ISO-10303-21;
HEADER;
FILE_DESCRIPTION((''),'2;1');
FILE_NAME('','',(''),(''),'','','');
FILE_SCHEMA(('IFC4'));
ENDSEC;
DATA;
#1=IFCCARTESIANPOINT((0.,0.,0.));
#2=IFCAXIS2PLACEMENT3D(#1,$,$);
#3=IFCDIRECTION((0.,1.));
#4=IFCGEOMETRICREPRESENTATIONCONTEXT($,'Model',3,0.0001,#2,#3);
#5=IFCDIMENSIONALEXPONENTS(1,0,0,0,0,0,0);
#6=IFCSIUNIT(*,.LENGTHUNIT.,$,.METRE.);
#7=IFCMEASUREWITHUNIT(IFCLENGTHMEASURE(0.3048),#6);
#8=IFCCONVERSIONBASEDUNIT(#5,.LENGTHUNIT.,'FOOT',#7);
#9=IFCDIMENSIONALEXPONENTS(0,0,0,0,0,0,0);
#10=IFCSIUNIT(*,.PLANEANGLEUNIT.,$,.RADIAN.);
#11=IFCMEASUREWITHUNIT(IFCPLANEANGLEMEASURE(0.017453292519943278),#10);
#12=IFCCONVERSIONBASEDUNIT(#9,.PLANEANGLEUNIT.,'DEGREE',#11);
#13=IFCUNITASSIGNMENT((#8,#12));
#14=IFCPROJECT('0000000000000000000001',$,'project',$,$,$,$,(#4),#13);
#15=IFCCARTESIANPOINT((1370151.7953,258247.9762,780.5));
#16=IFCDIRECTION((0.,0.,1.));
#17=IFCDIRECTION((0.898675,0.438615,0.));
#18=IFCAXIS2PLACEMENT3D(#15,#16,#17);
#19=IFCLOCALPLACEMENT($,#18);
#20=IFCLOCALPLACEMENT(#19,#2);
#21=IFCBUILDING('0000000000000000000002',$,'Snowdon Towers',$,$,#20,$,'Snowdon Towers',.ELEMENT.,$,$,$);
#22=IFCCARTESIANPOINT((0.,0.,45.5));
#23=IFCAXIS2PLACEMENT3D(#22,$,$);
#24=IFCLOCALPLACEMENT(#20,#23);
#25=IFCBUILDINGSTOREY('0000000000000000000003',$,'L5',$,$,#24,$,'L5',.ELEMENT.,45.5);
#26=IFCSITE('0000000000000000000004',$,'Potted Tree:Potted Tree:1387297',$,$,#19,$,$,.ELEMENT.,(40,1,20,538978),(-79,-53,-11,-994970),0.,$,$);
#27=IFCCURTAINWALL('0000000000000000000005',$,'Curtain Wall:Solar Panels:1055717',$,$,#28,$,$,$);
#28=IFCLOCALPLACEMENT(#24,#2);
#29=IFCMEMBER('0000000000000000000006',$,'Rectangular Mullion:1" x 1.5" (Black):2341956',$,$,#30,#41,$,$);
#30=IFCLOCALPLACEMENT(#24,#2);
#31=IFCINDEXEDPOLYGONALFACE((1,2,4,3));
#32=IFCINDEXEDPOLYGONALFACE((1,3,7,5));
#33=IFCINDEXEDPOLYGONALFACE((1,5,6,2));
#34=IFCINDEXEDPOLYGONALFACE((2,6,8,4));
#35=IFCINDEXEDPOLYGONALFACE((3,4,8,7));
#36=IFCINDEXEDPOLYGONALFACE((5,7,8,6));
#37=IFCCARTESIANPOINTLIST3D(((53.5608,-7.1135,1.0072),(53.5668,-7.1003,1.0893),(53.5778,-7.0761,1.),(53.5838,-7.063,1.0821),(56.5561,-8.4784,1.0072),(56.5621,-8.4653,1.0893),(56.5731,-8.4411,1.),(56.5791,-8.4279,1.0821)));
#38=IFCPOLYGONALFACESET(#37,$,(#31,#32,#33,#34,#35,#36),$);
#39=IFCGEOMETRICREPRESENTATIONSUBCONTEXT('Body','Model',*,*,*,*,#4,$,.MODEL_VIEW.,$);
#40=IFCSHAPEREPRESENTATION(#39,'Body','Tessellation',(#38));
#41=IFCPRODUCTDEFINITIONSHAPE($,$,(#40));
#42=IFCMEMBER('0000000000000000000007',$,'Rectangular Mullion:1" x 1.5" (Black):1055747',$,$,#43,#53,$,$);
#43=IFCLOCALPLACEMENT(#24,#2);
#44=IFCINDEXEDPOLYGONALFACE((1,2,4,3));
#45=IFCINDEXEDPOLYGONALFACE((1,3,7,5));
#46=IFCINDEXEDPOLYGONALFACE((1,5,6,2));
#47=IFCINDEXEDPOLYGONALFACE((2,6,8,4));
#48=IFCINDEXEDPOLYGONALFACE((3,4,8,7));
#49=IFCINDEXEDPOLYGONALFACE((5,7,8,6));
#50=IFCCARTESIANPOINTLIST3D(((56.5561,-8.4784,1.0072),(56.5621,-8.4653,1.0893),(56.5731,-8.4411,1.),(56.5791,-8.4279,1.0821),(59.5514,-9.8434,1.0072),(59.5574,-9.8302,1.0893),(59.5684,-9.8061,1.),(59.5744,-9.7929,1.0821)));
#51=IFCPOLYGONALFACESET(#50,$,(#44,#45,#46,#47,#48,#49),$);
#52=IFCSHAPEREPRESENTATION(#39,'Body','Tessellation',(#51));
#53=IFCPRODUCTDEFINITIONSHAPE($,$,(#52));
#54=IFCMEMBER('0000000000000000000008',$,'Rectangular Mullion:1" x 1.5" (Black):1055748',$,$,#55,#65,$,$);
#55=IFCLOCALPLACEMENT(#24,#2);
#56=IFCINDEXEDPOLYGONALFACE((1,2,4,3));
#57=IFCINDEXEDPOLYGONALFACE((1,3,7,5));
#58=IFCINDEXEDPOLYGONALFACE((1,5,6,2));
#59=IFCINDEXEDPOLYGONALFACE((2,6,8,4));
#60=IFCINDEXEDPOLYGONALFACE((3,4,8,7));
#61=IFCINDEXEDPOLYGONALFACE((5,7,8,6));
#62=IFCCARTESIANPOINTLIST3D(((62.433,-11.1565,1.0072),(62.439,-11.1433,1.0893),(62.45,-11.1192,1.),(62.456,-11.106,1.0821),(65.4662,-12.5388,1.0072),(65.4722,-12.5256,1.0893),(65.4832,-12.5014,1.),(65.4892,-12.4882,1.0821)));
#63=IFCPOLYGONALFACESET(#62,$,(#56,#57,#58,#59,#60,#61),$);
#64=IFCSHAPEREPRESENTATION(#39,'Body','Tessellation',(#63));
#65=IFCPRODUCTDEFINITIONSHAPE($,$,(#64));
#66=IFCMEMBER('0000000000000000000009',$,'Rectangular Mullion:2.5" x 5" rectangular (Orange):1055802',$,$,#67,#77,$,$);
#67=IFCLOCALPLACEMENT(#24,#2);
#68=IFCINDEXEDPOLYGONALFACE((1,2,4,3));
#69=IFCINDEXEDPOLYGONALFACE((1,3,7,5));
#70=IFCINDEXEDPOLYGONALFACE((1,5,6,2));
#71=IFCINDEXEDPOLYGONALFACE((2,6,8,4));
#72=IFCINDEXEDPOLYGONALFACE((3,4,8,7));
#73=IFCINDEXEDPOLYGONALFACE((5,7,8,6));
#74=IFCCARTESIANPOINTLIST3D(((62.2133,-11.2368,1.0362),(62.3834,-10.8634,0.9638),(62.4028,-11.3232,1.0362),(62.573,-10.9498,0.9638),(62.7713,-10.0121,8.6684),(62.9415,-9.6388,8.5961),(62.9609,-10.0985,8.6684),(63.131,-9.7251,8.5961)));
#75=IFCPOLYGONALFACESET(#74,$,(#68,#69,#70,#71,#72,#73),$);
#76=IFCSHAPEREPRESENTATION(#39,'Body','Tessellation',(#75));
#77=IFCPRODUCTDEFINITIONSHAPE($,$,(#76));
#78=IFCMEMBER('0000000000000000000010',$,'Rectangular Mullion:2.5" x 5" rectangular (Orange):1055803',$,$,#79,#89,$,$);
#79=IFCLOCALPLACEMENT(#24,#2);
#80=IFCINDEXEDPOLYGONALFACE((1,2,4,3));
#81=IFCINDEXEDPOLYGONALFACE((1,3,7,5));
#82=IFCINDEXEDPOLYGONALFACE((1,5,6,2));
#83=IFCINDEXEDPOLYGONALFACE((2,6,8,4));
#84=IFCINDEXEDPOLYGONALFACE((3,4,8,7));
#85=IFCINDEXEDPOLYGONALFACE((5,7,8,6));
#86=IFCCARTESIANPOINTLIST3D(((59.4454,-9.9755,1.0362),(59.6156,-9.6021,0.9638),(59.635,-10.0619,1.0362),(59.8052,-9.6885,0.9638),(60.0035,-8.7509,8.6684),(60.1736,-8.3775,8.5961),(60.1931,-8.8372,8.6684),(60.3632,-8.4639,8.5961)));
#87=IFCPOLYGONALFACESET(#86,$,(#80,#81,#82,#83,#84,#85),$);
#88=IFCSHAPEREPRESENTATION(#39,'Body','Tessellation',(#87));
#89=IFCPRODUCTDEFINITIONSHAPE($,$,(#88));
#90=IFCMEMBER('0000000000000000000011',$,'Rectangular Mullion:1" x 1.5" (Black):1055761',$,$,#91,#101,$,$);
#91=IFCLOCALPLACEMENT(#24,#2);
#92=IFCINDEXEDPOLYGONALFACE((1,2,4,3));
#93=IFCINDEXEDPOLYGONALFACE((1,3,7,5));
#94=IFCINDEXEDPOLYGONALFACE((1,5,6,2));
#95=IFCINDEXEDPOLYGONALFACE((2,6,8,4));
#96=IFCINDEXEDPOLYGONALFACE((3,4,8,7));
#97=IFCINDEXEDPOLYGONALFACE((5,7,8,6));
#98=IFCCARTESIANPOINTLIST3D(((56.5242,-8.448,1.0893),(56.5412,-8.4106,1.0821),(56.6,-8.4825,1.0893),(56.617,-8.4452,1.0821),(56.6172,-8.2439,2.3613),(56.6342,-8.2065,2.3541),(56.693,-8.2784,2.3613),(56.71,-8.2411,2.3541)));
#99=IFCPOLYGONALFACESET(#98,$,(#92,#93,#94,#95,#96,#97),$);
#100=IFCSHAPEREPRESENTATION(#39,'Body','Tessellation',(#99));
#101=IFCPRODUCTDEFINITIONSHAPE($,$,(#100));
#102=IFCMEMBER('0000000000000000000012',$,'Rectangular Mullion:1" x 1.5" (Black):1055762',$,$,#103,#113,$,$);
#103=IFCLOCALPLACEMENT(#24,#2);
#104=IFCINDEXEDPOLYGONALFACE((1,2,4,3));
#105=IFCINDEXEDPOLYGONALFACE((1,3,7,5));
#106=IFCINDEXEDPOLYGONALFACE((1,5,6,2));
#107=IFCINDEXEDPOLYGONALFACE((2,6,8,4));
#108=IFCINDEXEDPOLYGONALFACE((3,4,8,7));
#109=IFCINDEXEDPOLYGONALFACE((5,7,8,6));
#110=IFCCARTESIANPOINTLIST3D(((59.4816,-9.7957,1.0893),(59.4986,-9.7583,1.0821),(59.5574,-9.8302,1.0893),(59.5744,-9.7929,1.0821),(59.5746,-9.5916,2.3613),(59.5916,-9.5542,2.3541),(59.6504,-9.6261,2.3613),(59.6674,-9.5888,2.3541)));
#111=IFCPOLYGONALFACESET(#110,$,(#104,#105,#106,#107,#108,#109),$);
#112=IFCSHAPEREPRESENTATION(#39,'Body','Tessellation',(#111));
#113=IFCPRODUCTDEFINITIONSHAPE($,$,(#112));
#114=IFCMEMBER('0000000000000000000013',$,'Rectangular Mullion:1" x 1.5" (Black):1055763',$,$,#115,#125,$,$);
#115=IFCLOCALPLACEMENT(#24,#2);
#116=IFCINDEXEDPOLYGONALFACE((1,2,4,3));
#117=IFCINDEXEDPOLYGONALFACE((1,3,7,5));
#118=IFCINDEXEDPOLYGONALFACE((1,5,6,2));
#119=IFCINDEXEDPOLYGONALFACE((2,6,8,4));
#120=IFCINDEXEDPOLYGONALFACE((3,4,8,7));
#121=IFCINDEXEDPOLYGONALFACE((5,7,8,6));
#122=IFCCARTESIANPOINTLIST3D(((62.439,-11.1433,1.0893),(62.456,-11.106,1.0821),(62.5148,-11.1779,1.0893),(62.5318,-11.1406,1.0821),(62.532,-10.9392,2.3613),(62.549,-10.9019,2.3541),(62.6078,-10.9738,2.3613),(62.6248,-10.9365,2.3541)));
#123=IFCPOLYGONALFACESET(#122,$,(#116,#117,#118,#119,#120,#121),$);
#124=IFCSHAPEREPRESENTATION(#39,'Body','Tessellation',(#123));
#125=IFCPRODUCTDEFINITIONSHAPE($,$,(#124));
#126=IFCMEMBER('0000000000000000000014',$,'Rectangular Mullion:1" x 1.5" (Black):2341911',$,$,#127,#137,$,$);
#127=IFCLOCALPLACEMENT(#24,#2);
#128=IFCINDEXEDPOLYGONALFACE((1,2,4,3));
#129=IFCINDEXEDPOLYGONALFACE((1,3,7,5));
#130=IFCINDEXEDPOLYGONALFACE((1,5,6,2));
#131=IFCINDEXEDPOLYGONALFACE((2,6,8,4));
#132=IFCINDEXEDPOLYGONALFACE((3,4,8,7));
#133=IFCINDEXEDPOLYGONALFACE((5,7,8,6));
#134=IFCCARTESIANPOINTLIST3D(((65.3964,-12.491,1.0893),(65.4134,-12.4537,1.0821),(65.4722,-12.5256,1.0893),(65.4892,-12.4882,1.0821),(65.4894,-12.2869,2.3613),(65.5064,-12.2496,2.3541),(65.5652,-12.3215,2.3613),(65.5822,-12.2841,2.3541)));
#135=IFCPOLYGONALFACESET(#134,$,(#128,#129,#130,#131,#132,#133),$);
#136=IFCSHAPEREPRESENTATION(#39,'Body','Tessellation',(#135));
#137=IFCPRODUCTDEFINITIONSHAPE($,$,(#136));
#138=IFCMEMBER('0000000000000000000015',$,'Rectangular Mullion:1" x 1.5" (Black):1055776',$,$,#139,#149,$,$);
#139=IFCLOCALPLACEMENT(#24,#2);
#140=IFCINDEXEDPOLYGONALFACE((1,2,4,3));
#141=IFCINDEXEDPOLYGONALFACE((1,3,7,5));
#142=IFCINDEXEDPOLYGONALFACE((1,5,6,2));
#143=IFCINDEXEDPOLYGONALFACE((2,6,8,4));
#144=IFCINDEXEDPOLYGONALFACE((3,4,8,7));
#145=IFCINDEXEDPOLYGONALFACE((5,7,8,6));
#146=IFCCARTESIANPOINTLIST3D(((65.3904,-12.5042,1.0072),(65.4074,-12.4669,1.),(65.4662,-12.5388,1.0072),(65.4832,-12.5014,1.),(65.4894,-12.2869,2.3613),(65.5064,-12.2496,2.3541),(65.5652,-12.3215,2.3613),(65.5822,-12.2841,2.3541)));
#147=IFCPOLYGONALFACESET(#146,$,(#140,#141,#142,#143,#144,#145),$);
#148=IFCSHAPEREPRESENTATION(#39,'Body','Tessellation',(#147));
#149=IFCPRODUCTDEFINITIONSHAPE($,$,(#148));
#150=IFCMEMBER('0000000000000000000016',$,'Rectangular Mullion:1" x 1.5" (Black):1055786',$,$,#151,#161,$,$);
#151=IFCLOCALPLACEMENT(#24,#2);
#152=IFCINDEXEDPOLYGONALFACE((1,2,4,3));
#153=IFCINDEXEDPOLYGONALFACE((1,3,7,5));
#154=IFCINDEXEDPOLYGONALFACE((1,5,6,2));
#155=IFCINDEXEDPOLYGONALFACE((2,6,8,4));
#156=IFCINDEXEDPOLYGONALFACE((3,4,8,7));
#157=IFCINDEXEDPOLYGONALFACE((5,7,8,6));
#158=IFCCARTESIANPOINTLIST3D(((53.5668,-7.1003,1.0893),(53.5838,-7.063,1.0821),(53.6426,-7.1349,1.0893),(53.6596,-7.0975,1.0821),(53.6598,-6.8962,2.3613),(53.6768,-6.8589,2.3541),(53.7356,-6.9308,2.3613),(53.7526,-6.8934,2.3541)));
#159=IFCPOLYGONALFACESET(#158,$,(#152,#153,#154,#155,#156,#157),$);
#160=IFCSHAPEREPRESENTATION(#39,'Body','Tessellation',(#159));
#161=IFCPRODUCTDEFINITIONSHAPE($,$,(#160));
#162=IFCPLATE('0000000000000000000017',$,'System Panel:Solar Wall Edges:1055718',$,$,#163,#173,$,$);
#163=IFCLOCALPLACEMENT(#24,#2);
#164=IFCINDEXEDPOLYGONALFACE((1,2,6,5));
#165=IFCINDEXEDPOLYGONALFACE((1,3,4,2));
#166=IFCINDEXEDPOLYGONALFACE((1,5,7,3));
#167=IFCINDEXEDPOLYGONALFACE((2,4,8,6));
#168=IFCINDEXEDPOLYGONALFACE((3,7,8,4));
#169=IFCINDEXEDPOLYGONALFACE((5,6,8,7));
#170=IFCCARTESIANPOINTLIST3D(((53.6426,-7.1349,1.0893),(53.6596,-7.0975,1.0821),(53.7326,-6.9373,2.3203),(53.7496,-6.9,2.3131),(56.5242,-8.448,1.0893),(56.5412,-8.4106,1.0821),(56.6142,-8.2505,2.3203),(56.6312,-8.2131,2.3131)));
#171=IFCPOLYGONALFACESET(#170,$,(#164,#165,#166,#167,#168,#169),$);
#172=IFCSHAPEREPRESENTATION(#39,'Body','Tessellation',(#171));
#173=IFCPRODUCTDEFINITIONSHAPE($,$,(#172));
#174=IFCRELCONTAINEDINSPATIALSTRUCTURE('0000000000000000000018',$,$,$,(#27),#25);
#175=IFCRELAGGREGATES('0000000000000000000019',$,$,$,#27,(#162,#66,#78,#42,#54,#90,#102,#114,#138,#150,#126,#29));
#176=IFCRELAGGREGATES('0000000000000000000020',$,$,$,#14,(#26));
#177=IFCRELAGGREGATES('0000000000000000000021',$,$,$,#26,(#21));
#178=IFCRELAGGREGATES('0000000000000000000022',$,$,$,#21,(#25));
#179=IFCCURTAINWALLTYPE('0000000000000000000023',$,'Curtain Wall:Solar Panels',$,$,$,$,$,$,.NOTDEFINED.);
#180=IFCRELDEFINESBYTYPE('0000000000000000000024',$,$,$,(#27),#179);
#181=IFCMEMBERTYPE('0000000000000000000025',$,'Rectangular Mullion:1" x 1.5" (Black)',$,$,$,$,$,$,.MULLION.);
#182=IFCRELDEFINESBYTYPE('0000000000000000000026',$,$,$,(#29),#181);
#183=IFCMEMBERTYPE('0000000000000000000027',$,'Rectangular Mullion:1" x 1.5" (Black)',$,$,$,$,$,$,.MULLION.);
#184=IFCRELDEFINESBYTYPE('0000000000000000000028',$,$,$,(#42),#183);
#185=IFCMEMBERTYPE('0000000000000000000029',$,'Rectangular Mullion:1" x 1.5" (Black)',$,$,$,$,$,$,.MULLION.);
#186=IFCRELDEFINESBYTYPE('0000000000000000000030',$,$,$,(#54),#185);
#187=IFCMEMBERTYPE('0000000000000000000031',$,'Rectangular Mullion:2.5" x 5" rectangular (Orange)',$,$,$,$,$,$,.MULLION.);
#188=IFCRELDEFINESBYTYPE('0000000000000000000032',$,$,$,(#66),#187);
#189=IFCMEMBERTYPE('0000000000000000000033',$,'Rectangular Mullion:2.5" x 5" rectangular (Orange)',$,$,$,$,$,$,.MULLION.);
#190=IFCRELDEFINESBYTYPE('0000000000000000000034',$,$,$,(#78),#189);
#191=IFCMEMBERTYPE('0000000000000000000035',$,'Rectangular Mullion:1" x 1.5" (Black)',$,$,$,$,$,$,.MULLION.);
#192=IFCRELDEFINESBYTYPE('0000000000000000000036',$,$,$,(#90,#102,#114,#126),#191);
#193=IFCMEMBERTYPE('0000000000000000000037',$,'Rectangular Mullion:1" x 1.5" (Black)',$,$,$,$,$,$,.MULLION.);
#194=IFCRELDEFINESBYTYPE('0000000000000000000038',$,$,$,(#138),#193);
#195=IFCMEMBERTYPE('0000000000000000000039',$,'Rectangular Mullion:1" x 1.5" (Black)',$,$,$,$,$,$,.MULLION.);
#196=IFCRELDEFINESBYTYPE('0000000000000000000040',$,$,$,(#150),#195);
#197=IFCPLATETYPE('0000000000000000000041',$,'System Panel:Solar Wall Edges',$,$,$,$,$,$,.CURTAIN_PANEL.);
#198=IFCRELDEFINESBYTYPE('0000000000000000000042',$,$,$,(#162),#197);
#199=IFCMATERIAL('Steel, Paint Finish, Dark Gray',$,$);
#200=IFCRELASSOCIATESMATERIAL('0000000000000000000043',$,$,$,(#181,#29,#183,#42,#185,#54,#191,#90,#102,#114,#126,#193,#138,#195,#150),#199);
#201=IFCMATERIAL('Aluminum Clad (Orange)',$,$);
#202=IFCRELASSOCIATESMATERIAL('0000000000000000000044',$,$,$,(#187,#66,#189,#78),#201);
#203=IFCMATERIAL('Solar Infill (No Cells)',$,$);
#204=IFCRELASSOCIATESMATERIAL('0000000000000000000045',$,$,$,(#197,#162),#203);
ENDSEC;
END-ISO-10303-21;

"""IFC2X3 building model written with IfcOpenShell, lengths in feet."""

from ifc_helpers import new_model, entity, si_unit, converted_unit, direction, frame, frame_2d, origin, origin_2d_with_axis, place, context, subcontext, project, spatial, rectangle, extrude, source, transform, mapped, material, type_object, type_shapes, element, aggregate, save


model = new_model("IFC2X3")

# Units and contexts
model_context = context("Model", 3, precision=0.0001, world=origin(), true_north=direction((0.0, 1.0)))
body_context = subcontext(model_context, "Body", "Model", "MODEL_VIEW")
ifc_project = project(units=[converted_unit("LENGTHUNIT", "FOOT", entity("IfcLengthMeasure", 0.3048), si_unit("LENGTHUNIT", "METRE"), dimensions=[1, 0, 0, 0, 0, 0, 0]), converted_unit("PLANEANGLEUNIT", "DEGREE", entity("IfcPlaneAngleMeasure", 0.017453292519943278), si_unit("PLANEANGLEUNIT", "RADIAN"), dimensions=[0, 0, 0, 0, 0, 0, 0])], contexts=[model_context])

# Site, building, storey
site_placement = place(None, frame((1370151.7953, 258247.9762, 780.5), z_axis=(0.0, 0.0, 1.0), x_axis=(0.898675, 0.438615, 0.0)))
site = spatial("IfcSite", under=ifc_project, at=site_placement, Name="Potted Tree:Potted Tree:1387297", CompositionType="ELEMENT", RefLatitude=(40, 1, 20, 538978), RefLongitude=(-79, -53, -11, -994970), RefElevation=0.0)
building_placement = place(site_placement, origin())
building = spatial("IfcBuilding", under=site, at=building_placement, Name="Snowdon Towers", LongName="Snowdon Towers", CompositionType="ELEMENT")
storey_placement = place(building_placement, frame((0.0, 0.0, 45.5)))
storey = spatial("IfcBuildingStorey", under=building, at=storey_placement, Name="L5", LongName="L5", CompositionType="ELEMENT", Elevation=45.5)

# Curtain wall, members, plate
curtain_wall_type = type_object("IfcCurtainWallType", Name="Curtain Wall:Solar Panels", PredefinedType="NOTDEFINED")
curtain_wall_placement = place(storey_placement, frame((0.0, 0.0, -45.5)))
curtain_wall = element("IfcCurtainWall", 1, at=curtain_wall_placement, inside=storey, type_object=curtain_wall_type, Name="Curtain Wall:Solar Panels:1055717")
ifc_material_1 = material(Name="Aluminum Clad (Orange)")
ifc_material_2 = material(Name="Steel, Paint Finish, Dark Gray")
member_type_1 = type_object("IfcMemberType", Name="Rectangular Mullion:1\" x 1.5\" (Black)", PredefinedType="MULLION", material=ifc_material_2)
shared_shape_1 = source(origin(), body_context, "Body", "SweptSolid", [
    extrude(rectangle(XDim=0.0833, YDim=0.0417, at=origin_2d_with_axis()), frame((-0.0417, 0.0208, -3.2917), z_axis=(0.0, 0.0, 1.0), x_axis=(-1.0, 0.0, 0.0)), (0.0, 0.0, 1.0), 3.2917),
])
type_shapes(member_type_1, [shared_shape_1])
member_1_placement = place(curtain_wall_placement, frame((53.5778, -7.0761, 46.5), z_axis=(-0.909972, 0.414671, 0.0), x_axis=(-0.072007, -0.158015, -0.984808)))
member_1 = element("IfcMember", 2, at=member_1_placement, type_object=member_type_1, material=ifc_material_2, Name="Rectangular Mullion:1\" x 1.5\" (Black):2341956", context=body_context, shape_type="MappedRepresentation", body=[
    mapped(shared_shape_1, transform((0.0, 0.0, 0.0), scale=1.0)),
])
member_type_2 = type_object("IfcMemberType", Name="Rectangular Mullion:1\" x 1.5\" (Black)", PredefinedType="MULLION", material=ifc_material_2)
shared_shape_2 = source(origin(), body_context, "Body", "SweptSolid", [
    extrude(rectangle(XDim=0.0833, YDim=0.0417, at=frame_2d((0.0, 0.0), x_axis=(1.0, 0.0))), frame((-0.0417, 0.0208, -3.2917), z_axis=(0.0, 0.0, 1.0), x_axis=(-1.0, 0.0, 0.0)), (0.0, 0.0, 1.0), 3.2917),
])
type_shapes(member_type_2, [shared_shape_2])
member_2_placement = place(curtain_wall_placement, frame((56.5731, -8.4411, 46.5), z_axis=(-0.909972, 0.414671, 0.0), x_axis=(-0.072007, -0.158015, -0.984808)))
member_2 = element("IfcMember", 3, at=member_2_placement, type_object=member_type_2, material=ifc_material_2, Name="Rectangular Mullion:1\" x 1.5\" (Black):1055747", context=body_context, shape_type="MappedRepresentation", body=[
    mapped(shared_shape_2, transform((0.0, 0.0, 0.0), scale=1.0)),
])
member_type_3 = type_object("IfcMemberType", Name="Rectangular Mullion:1\" x 1.5\" (Black)", PredefinedType="MULLION", material=ifc_material_2)
shared_shape_3 = source(origin(), body_context, "Body", "SweptSolid", [
    extrude(rectangle(XDim=0.0833, YDim=0.0417, at=origin_2d_with_axis()), frame((-0.0417, 0.0208, -3.3333), z_axis=(0.0, 0.0, 1.0), x_axis=(-1.0, 0.0, 0.0)), (0.0, 0.0, 1.0), 3.3333),
])
type_shapes(member_type_3, [shared_shape_3])
member_3_placement = place(curtain_wall_placement, frame((62.45, -11.1192, 46.5), z_axis=(-0.909972, 0.414671, 0.0), x_axis=(-0.072007, -0.158015, -0.984808)))
member_3 = element("IfcMember", 4, at=member_3_placement, type_object=member_type_3, material=ifc_material_2, Name="Rectangular Mullion:1\" x 1.5\" (Black):1055748", context=body_context, shape_type="MappedRepresentation", body=[
    mapped(shared_shape_3, transform((0.0, 0.0, 0.0), scale=1.0)),
])
member_type_4 = type_object("IfcMemberType", Name="Rectangular Mullion:2.5\" x 5\" rectangular (Orange)", PredefinedType="MULLION", material=ifc_material_1)
shared_shape_4 = source(origin(), body_context, "Body", "SweptSolid", [
    extrude(rectangle(XDim=0.2083, YDim=0.4167, at=frame_2d((0.0, 0.0), x_axis=(1.0, 0.0))), frame((-0.1042, 0.0, -7.75), z_axis=(0.0, 0.0, 1.0), x_axis=(-1.0, 0.0, 0.0)), (0.0, 0.0, 1.0), 7.75),
])
type_shapes(member_type_4, [shared_shape_4])
member_4_placement = place(curtain_wall_placement, frame((62.4879, -11.1365, 46.5), z_axis=(-0.072007, -0.158015, -0.984808), x_axis=(0.909972, -0.414671, 0.0)))
member_4 = element("IfcMember", 5, at=member_4_placement, type_object=member_type_4, material=ifc_material_1, Name="Rectangular Mullion:2.5\" x 5\" rectangular (Orange):1055802", context=body_context, shape_type="MappedRepresentation", body=[
    mapped(shared_shape_4, transform((0.0, 0.0, 0.0), scale=1.0)),
])
member_type_5 = type_object("IfcMemberType", Name="Rectangular Mullion:2.5\" x 5\" rectangular (Orange)", PredefinedType="MULLION", material=ifc_material_1)
shared_shape_5 = source(origin(), body_context, "Body", "SweptSolid", [
    extrude(rectangle(XDim=0.2083, YDim=0.4167, at=frame_2d((0.0, 0.0), x_axis=(1.0, 0.0))), frame((-0.1042, 0.0, -7.75), z_axis=(0.0, 0.0, 1.0), x_axis=(-1.0, 0.0, 0.0)), (0.0, 0.0, 1.0), 7.75),
])
type_shapes(member_type_5, [shared_shape_5])
member_5_placement = place(curtain_wall_placement, frame((60.0886, -8.5642, 54.1323), z_axis=(0.072007, 0.158015, 0.984808), x_axis=(-0.909972, 0.414671, 0.0)))
member_5 = element("IfcMember", 6, at=member_5_placement, type_object=member_type_5, material=ifc_material_1, Name="Rectangular Mullion:2.5\" x 5\" rectangular (Orange):1055803", context=body_context, shape_type="MappedRepresentation", body=[
    mapped(shared_shape_5, transform((0.0, 0.0, 0.0), scale=1.0)),
])
member_type_6 = type_object("IfcMemberType", Name="Rectangular Mullion:1\" x 1.5\" (Black)", PredefinedType="MULLION", material=ifc_material_2)
shared_shape_6 = source(origin(), body_context, "Body", "SweptSolid", [
    extrude(rectangle(XDim=0.0833, YDim=0.0417, at=origin_2d_with_axis()), frame((0.0, 0.0208, -1.2917), z_axis=(0.0, 0.0, 1.0), x_axis=(-1.0, 0.0, 0.0)), (0.0, 0.0, 1.0), 1.2917),
])
type_shapes(member_type_6, [shared_shape_6])
member_6_placement = place(curtain_wall_placement, frame((56.5791, -8.4279, 46.5821), z_axis=(-0.072007, -0.158015, -0.984808), x_axis=(0.909972, -0.414671, 0.0)))
member_6 = element("IfcMember", 7, at=member_6_placement, type_object=member_type_6, material=ifc_material_2, Name="Rectangular Mullion:1\" x 1.5\" (Black):1055761", context=body_context, shape_type="MappedRepresentation", body=[
    mapped(shared_shape_6, transform((0.0, 0.0, 0.0), scale=1.0)),
])
member_7_placement = place(curtain_wall_placement, frame((59.5365, -9.7756, 46.5821), z_axis=(-0.072007, -0.158015, -0.984808), x_axis=(0.909972, -0.414671, 0.0)))
member_7 = element("IfcMember", 8, at=member_7_placement, type_object=member_type_6, material=ifc_material_2, Name="Rectangular Mullion:1\" x 1.5\" (Black):1055762", context=body_context, shape_type="MappedRepresentation", body=[
    mapped(shared_shape_6, transform((0.0, 0.0, 0.0), scale=1.0)),
])
member_8_placement = place(curtain_wall_placement, frame((62.4939, -11.1233, 46.5821), z_axis=(-0.072007, -0.158015, -0.984808), x_axis=(0.909972, -0.414671, 0.0)))
member_8 = element("IfcMember", 9, at=member_8_placement, type_object=member_type_6, material=ifc_material_2, Name="Rectangular Mullion:1\" x 1.5\" (Black):1055763", context=body_context, shape_type="MappedRepresentation", body=[
    mapped(shared_shape_6, transform((0.0, 0.0, 0.0), scale=1.0)),
])
member_9_placement = place(curtain_wall_placement, frame((65.4513, -12.471, 46.5821), z_axis=(-0.072007, -0.158015, -0.984808), x_axis=(0.909972, -0.414671, 0.0)))
member_9 = element("IfcMember", 10, at=member_9_placement, type_object=member_type_6, material=ifc_material_2, Name="Rectangular Mullion:1\" x 1.5\" (Black):2341911", context=body_context, shape_type="MappedRepresentation", body=[
    mapped(shared_shape_6, transform((0.0, 0.0, 0.0), scale=1.0)),
])
member_type_7 = type_object("IfcMemberType", Name="Rectangular Mullion:1\" x 1.5\" (Black)", PredefinedType="MULLION", material=ifc_material_2)
shared_shape_7 = source(origin(), body_context, "Body", "SweptSolid", [
    extrude(rectangle(XDim=0.0833, YDim=0.0417, at=frame_2d((0.0, 0.0), x_axis=(1.0, 0.0))), frame((-0.0417, 0.0208, -1.375), z_axis=(0.0, 0.0, 1.0), x_axis=(-1.0, 0.0, 0.0)), (0.0, 0.0, 1.0), 1.375),
])
type_shapes(member_type_7, [shared_shape_7])
member_10_placement = place(curtain_wall_placement, frame((65.4832, -12.5014, 46.5), z_axis=(-0.072007, -0.158015, -0.984808), x_axis=(0.909972, -0.414671, 0.0)))
member_10 = element("IfcMember", 11, at=member_10_placement, type_object=member_type_7, material=ifc_material_2, Name="Rectangular Mullion:1\" x 1.5\" (Black):1055776", context=body_context, shape_type="MappedRepresentation", body=[
    mapped(shared_shape_7, transform((0.0, 0.0, 0.0), scale=1.0)),
])
member_type_8 = type_object("IfcMemberType", Name="Rectangular Mullion:1\" x 1.5\" (Black)", PredefinedType="MULLION", material=ifc_material_2)
shared_shape_8 = source(origin(), body_context, "Body", "SweptSolid", [
    extrude(rectangle(XDim=0.0833, YDim=0.0417, at=origin_2d_with_axis()), frame((-0.0417, 0.0208, -1.2917), z_axis=(0.0, 0.0, 1.0), x_axis=(-1.0, 0.0, 0.0)), (0.0, 0.0, 1.0), 1.2917),
])
type_shapes(member_type_8, [shared_shape_8])
member_11_placement = place(curtain_wall_placement, frame((53.6768, -6.8589, 47.8541), z_axis=(0.072007, 0.158015, 0.984808), x_axis=(-0.909972, 0.414671, 0.0)))
member_11 = element("IfcMember", 12, at=member_11_placement, type_object=member_type_8, material=ifc_material_2, Name="Rectangular Mullion:1\" x 1.5\" (Black):1055786", context=body_context, shape_type="MappedRepresentation", body=[
    mapped(shared_shape_8, transform((0.0, 0.0, 0.0), scale=1.0)),
])
ifc_material_3 = material(Name="Solar Infill (No Cells)")
plate_type_1 = type_object("IfcPlateType", Name="System Panel:Solar Wall Edges", PredefinedType="CURTAIN_PANEL", material=ifc_material_3)
shared_shape_9 = source(origin(), body_context, "Body", "SweptSolid", [
    extrude(rectangle(XDim=0.0417, YDim=3.1667, at=frame_2d((0.0, 0.0), x_axis=(1.0, 0.0))), frame((0.0, -0.0208, 0.0), z_axis=(0.0, 0.0, 1.0), x_axis=(0.0, 1.0, 0.0)), (0.0, 0.0, 1.0), 1.25),
])
type_shapes(plate_type_1, [shared_shape_9])
plate_1_placement = place(curtain_wall_placement, frame((55.1004, -7.7541, 46.5821), z_axis=(0.072007, 0.158015, 0.984808), x_axis=(0.909972, -0.414671, 0.0)))
plate_1 = element("IfcPlate", 13, at=plate_1_placement, type_object=plate_type_1, material=ifc_material_3, Name="System Panel:Solar Wall Edges:1055718", context=body_context, shape_type="MappedRepresentation", body=[
    mapped(shared_shape_9, transform((0.0, 0.0, 0.0), scale=1.0)),
])
aggregate(curtain_wall, [plate_1, member_4, member_5, member_2, member_3, member_6, member_7, member_8, member_10, member_11, member_9, member_1])

save(model, "model.ifc")
